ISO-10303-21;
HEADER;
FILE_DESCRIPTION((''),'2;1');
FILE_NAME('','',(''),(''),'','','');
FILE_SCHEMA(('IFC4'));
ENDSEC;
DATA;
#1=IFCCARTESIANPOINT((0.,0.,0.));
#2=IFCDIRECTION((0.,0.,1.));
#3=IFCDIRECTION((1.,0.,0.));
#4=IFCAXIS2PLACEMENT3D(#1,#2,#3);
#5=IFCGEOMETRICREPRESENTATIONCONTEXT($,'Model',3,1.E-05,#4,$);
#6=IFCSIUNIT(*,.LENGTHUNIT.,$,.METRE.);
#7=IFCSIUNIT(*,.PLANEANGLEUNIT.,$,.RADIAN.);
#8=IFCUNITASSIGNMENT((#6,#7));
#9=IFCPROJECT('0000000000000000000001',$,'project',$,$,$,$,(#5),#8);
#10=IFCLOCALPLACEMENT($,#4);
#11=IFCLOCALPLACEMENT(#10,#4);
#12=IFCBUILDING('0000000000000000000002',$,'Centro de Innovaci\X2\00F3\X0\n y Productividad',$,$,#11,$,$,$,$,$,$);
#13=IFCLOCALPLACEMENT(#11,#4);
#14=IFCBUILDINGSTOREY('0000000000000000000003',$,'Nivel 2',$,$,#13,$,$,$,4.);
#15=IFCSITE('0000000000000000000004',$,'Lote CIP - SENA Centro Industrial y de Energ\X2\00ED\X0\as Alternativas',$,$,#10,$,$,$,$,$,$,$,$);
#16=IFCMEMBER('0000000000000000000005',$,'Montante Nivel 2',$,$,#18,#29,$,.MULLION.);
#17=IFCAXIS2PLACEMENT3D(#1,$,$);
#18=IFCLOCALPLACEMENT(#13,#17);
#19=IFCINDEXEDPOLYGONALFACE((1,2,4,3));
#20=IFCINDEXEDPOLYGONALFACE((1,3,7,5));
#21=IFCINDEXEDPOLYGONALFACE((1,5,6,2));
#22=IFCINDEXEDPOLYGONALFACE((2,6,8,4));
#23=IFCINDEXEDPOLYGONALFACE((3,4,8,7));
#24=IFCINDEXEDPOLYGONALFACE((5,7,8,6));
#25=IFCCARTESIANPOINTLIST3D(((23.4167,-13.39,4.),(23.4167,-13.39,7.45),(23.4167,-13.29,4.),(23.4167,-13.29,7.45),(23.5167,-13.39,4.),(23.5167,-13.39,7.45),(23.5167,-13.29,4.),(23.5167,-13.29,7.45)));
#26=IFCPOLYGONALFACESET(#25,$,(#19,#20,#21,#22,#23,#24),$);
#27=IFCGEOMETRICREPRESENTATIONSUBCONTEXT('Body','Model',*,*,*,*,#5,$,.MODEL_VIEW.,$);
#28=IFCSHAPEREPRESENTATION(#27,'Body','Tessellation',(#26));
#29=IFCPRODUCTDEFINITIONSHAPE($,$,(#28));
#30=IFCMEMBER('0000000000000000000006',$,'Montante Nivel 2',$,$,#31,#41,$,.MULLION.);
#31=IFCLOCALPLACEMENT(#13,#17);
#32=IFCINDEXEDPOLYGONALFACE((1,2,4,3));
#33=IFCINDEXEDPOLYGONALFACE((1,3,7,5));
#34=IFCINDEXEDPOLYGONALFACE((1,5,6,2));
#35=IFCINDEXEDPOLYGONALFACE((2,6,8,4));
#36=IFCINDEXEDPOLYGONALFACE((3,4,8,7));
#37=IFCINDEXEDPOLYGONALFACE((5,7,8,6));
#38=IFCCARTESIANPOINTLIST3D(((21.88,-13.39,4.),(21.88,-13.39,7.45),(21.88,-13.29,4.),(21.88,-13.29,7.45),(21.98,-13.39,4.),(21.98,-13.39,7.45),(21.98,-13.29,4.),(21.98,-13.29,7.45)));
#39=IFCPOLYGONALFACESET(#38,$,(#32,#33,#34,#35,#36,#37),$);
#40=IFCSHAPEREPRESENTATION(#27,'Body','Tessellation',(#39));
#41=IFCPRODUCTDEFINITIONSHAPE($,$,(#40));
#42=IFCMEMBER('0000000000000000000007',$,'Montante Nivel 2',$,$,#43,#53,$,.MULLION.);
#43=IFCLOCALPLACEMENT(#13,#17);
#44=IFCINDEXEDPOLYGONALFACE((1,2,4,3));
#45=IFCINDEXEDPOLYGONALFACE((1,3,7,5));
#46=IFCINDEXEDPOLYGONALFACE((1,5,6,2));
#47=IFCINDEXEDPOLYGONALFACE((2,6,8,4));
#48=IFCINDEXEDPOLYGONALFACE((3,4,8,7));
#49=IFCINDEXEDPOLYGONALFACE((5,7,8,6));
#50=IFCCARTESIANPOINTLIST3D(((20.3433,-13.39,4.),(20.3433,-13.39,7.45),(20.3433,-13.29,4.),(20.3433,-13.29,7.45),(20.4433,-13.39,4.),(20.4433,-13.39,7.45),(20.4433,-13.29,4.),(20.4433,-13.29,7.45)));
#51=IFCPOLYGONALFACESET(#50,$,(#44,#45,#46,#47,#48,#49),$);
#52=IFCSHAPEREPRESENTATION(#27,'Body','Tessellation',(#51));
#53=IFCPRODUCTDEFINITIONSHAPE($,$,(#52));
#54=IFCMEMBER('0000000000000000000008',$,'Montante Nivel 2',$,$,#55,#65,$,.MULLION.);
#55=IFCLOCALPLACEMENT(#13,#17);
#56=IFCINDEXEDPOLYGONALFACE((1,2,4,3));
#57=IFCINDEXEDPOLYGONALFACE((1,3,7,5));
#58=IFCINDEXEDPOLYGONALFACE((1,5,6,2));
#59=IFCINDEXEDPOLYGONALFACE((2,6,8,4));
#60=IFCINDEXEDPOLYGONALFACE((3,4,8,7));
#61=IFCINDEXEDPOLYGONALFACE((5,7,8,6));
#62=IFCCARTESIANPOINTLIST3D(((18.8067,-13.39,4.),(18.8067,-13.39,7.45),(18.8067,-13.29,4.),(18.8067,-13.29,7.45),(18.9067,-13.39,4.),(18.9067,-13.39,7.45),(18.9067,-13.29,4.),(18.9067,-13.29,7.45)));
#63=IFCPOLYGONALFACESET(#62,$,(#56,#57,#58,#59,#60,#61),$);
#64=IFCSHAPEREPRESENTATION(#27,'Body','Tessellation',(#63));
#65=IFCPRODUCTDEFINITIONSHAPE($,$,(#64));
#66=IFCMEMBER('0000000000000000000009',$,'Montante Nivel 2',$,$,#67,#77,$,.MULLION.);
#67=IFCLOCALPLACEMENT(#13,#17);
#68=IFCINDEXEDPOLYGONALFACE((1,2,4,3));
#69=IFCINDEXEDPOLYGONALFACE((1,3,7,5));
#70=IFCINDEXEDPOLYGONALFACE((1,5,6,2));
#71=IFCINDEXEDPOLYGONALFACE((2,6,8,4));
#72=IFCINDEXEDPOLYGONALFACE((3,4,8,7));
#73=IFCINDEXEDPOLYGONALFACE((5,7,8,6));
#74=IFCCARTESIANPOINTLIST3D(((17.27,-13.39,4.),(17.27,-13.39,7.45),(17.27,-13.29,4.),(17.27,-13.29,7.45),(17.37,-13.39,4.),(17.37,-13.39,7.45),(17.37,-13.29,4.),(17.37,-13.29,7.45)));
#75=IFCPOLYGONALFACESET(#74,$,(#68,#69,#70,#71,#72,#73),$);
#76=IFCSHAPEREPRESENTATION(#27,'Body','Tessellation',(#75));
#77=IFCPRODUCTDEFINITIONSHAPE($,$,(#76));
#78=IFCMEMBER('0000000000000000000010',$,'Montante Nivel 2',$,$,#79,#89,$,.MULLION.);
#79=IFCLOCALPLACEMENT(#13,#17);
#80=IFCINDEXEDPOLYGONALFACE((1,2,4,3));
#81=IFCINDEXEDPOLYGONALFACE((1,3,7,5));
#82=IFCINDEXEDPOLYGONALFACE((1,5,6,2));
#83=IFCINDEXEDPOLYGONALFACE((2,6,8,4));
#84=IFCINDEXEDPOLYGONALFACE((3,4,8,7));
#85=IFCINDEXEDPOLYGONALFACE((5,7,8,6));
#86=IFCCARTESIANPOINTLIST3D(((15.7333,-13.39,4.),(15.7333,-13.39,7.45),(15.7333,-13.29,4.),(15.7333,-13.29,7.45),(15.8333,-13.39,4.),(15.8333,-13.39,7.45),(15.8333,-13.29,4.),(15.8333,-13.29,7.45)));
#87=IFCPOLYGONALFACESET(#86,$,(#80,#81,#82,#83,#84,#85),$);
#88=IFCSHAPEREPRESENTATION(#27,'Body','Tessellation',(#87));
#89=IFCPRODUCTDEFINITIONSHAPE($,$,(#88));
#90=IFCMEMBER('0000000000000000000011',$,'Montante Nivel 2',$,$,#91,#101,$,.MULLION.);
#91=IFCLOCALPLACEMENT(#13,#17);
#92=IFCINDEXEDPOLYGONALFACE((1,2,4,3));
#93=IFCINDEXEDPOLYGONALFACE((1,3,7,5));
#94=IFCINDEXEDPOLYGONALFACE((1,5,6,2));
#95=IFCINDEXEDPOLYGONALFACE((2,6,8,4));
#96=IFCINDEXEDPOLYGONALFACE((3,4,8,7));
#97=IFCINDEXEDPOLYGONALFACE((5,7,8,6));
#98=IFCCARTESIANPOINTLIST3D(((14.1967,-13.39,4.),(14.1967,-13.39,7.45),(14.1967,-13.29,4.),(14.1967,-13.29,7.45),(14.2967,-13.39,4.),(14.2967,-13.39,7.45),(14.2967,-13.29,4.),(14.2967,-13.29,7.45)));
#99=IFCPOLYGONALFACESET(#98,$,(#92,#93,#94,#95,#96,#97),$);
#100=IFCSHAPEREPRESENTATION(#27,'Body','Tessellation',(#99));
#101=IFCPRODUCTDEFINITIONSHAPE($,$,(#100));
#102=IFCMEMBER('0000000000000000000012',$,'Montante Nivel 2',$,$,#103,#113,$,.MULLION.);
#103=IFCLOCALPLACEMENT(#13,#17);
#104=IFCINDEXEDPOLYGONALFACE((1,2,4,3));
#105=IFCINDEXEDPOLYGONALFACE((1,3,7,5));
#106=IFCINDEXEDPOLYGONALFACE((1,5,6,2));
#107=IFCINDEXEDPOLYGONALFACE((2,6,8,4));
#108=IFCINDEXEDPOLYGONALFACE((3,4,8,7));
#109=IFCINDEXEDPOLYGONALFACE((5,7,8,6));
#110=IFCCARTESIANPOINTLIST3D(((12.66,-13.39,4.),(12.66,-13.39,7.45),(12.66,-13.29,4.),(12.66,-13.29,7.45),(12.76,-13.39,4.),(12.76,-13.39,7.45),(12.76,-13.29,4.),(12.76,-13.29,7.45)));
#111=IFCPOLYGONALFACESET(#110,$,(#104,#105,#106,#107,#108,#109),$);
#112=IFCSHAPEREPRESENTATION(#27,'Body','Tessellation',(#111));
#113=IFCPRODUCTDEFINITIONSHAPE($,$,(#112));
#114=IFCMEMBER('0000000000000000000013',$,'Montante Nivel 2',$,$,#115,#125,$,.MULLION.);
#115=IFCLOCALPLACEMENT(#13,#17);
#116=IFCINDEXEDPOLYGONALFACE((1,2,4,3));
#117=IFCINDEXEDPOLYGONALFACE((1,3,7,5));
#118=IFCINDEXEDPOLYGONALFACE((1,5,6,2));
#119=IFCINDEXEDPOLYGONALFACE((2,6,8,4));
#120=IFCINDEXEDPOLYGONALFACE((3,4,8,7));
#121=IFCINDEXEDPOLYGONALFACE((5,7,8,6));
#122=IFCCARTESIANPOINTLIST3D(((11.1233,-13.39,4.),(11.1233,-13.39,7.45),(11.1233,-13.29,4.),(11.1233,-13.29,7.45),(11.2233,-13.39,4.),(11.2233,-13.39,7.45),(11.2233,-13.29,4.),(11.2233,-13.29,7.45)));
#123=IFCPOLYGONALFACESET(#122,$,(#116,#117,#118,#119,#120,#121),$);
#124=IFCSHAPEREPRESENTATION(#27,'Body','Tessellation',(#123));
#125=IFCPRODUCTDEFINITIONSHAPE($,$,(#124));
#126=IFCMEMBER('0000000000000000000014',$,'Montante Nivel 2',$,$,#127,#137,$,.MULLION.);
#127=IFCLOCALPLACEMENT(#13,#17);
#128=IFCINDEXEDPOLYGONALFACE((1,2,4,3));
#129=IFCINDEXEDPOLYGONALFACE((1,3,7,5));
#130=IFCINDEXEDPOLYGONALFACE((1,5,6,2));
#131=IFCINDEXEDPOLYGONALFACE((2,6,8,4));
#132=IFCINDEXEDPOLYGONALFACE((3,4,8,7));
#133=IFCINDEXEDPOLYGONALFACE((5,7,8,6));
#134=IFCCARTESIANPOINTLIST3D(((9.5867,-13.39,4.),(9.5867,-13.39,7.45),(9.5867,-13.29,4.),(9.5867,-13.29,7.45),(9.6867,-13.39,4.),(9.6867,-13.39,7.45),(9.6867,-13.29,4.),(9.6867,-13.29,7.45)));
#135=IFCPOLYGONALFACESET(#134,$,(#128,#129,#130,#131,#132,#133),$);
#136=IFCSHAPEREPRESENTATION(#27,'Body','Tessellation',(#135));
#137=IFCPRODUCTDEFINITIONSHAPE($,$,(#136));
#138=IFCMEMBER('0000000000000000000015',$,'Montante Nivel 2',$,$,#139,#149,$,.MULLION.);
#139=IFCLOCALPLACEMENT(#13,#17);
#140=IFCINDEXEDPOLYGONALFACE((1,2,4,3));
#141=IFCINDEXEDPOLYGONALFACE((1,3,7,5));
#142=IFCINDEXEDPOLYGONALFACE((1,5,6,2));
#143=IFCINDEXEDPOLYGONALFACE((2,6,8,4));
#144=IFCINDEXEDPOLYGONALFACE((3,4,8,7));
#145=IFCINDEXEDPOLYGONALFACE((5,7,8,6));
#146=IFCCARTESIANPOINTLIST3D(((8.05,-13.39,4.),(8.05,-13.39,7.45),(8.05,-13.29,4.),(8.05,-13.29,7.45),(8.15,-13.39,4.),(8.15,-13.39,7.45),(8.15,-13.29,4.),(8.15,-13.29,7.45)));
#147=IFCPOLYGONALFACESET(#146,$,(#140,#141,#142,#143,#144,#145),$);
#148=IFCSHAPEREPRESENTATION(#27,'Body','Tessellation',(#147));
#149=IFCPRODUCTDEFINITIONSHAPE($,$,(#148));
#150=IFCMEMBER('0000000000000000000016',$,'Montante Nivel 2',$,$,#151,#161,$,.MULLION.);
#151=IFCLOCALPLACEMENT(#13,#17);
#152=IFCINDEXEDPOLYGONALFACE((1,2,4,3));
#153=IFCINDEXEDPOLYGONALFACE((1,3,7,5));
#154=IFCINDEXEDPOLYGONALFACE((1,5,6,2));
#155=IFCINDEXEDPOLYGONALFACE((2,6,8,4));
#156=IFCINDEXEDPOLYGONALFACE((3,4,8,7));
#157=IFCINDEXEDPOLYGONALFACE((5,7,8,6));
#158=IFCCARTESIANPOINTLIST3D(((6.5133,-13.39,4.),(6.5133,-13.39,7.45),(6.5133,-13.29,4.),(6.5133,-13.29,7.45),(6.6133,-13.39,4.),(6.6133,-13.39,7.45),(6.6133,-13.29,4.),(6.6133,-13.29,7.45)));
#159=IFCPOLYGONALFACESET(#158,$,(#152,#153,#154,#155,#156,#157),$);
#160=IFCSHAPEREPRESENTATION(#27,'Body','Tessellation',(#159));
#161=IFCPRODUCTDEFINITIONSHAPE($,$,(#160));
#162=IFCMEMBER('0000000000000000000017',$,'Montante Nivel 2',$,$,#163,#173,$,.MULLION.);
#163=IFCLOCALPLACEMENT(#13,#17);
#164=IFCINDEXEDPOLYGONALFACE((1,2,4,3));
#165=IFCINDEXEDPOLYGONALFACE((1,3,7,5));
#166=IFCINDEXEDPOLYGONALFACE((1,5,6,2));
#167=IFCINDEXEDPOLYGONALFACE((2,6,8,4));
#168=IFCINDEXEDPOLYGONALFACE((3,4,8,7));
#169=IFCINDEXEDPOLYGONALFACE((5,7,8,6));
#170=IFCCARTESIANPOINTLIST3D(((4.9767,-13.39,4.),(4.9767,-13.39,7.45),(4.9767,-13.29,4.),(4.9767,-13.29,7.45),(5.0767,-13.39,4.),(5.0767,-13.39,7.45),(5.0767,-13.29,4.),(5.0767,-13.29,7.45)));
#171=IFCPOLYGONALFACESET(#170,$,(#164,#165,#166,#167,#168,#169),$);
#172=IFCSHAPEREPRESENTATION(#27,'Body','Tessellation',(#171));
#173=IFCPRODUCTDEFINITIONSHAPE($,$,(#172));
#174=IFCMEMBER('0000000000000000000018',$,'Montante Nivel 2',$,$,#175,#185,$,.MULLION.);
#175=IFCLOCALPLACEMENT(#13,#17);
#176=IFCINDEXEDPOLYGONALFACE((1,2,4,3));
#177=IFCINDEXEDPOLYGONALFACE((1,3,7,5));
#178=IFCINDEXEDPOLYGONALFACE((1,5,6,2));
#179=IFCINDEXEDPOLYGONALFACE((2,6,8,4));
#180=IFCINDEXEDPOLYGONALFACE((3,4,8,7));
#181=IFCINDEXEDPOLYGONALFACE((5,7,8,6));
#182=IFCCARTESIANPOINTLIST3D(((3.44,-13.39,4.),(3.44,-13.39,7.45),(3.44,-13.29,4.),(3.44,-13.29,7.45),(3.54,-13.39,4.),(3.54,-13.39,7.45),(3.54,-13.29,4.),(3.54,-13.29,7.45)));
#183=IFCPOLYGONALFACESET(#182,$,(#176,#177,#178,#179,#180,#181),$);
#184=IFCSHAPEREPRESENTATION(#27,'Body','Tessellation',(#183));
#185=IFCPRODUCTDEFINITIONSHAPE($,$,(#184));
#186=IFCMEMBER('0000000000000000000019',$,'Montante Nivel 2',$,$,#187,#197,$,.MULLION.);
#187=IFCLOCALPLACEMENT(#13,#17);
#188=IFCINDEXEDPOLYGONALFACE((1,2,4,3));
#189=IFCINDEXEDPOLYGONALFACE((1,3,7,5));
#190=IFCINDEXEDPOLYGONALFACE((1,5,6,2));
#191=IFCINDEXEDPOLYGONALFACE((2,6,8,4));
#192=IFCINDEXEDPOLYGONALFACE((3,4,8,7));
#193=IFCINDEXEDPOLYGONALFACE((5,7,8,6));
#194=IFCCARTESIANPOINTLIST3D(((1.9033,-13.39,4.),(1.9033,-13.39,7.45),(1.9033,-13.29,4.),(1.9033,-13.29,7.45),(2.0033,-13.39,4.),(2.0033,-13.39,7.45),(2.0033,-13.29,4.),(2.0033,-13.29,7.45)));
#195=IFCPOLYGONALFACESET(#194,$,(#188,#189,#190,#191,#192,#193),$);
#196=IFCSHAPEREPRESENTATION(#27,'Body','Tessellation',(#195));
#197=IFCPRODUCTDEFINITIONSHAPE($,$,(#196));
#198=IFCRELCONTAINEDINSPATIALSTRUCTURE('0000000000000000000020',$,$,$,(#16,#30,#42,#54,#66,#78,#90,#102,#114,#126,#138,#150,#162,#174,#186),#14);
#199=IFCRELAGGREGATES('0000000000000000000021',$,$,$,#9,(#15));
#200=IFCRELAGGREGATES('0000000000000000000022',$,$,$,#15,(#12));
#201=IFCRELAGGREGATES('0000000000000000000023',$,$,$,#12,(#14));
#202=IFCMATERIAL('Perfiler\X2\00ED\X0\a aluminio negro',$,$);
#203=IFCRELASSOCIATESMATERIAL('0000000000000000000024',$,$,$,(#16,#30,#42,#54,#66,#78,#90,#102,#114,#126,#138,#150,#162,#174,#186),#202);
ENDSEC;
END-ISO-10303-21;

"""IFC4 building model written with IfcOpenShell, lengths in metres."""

from ifc_helpers import new_model, si_unit, frame, origin_with_axes, place, context, subcontext, project, spatial, polyline, outline, extrude, material, element, save


model = new_model("IFC4")

# Units and contexts
model_context = context("Model", 3, precision=1e-05, world=origin_with_axes())
body_context = subcontext(model_context, "Body", "Model", "MODEL_VIEW")
ifc_project = project(units=[si_unit("LENGTHUNIT", "METRE"), si_unit("PLANEANGLEUNIT", "RADIAN")], contexts=[model_context])

# Site, building, storey
site_placement = place(None, origin_with_axes())
site = spatial("IfcSite", under=ifc_project, at=site_placement, Name="Lote CIP - SENA Centro Industrial y de Energías Alternativas")
building_placement = place(site_placement, origin_with_axes())
building = spatial("IfcBuilding", under=site, at=building_placement, Name="Centro de Innovación y Productividad")
storey_placement = place(building_placement, origin_with_axes())
storey = spatial("IfcBuildingStorey", under=building, at=storey_placement, Name="Nivel 2", Elevation=4.0)

# Members
ifc_material_1 = material(Name="Perfilería aluminio negro")
member_1_placement = place(storey_placement, origin_with_axes())
element("IfcMember", 1, at=member_1_placement, inside=storey, material=ifc_material_1, Name="Montante Nivel 2", PredefinedType="MULLION", context=body_context, shape_type="SweptSolid", body=[
    extrude(outline(polyline([(23.5167, -13.29), (23.5167, -13.39), (23.4167, -13.39), (23.4167, -13.29), (23.5167, -13.29)])), frame((0.0, 0.0, 4.0)), (0.0, 0.0, 1.0), 3.45),
])
member_2_placement = place(storey_placement, origin_with_axes())
element("IfcMember", 2, at=member_2_placement, inside=storey, material=ifc_material_1, Name="Montante Nivel 2", PredefinedType="MULLION", context=body_context, shape_type="SweptSolid", body=[
    extrude(outline(polyline([(21.98, -13.29), (21.98, -13.39), (21.88, -13.39), (21.88, -13.29), (21.98, -13.29)])), frame((0.0, 0.0, 4.0)), (0.0, 0.0, 1.0), 3.45),
])
member_3_placement = place(storey_placement, origin_with_axes())
element("IfcMember", 3, at=member_3_placement, inside=storey, material=ifc_material_1, Name="Montante Nivel 2", PredefinedType="MULLION", context=body_context, shape_type="SweptSolid", body=[
    extrude(outline(polyline([(20.4433, -13.29), (20.4433, -13.39), (20.3433, -13.39), (20.3433, -13.29), (20.4433, -13.29)])), frame((0.0, 0.0, 4.0)), (0.0, 0.0, 1.0), 3.45),
])
member_4_placement = place(storey_placement, origin_with_axes())
element("IfcMember", 4, at=member_4_placement, inside=storey, material=ifc_material_1, Name="Montante Nivel 2", PredefinedType="MULLION", context=body_context, shape_type="SweptSolid", body=[
    extrude(outline(polyline([(18.9067, -13.29), (18.9067, -13.39), (18.8067, -13.39), (18.8067, -13.29), (18.9067, -13.29)])), frame((0.0, 0.0, 4.0)), (0.0, 0.0, 1.0), 3.45),
])
member_5_placement = place(storey_placement, origin_with_axes())
element("IfcMember", 5, at=member_5_placement, inside=storey, material=ifc_material_1, Name="Montante Nivel 2", PredefinedType="MULLION", context=body_context, shape_type="SweptSolid", body=[
    extrude(outline(polyline([(17.37, -13.29), (17.37, -13.39), (17.27, -13.39), (17.27, -13.29), (17.37, -13.29)])), frame((0.0, 0.0, 4.0)), (0.0, 0.0, 1.0), 3.45),
])
member_6_placement = place(storey_placement, origin_with_axes())
element("IfcMember", 6, at=member_6_placement, inside=storey, material=ifc_material_1, Name="Montante Nivel 2", PredefinedType="MULLION", context=body_context, shape_type="SweptSolid", body=[
    extrude(outline(polyline([(15.8333, -13.29), (15.8333, -13.39), (15.7333, -13.39), (15.7333, -13.29), (15.8333, -13.29)])), frame((0.0, 0.0, 4.0)), (0.0, 0.0, 1.0), 3.45),
])
member_7_placement = place(storey_placement, origin_with_axes())
element("IfcMember", 7, at=member_7_placement, inside=storey, material=ifc_material_1, Name="Montante Nivel 2", PredefinedType="MULLION", context=body_context, shape_type="SweptSolid", body=[
    extrude(outline(polyline([(14.2967, -13.29), (14.2967, -13.39), (14.1967, -13.39), (14.1967, -13.29), (14.2967, -13.29)])), frame((0.0, 0.0, 4.0)), (0.0, 0.0, 1.0), 3.45),
])
member_8_placement = place(storey_placement, origin_with_axes())
element("IfcMember", 8, at=member_8_placement, inside=storey, material=ifc_material_1, Name="Montante Nivel 2", PredefinedType="MULLION", context=body_context, shape_type="SweptSolid", body=[
    extrude(outline(polyline([(12.76, -13.29), (12.76, -13.39), (12.66, -13.39), (12.66, -13.29), (12.76, -13.29)])), frame((0.0, 0.0, 4.0)), (0.0, 0.0, 1.0), 3.45),
])
member_9_placement = place(storey_placement, origin_with_axes())
element("IfcMember", 9, at=member_9_placement, inside=storey, material=ifc_material_1, Name="Montante Nivel 2", PredefinedType="MULLION", context=body_context, shape_type="SweptSolid", body=[
    extrude(outline(polyline([(11.2233, -13.29), (11.2233, -13.39), (11.1233, -13.39), (11.1233, -13.29), (11.2233, -13.29)])), frame((0.0, 0.0, 4.0)), (0.0, 0.0, 1.0), 3.45),
])
member_10_placement = place(storey_placement, origin_with_axes())
element("IfcMember", 10, at=member_10_placement, inside=storey, material=ifc_material_1, Name="Montante Nivel 2", PredefinedType="MULLION", context=body_context, shape_type="SweptSolid", body=[
    extrude(outline(polyline([(9.6867, -13.29), (9.6867, -13.39), (9.5867, -13.39), (9.5867, -13.29), (9.6867, -13.29)])), frame((0.0, 0.0, 4.0)), (0.0, 0.0, 1.0), 3.45),
])
member_11_placement = place(storey_placement, origin_with_axes())
element("IfcMember", 11, at=member_11_placement, inside=storey, material=ifc_material_1, Name="Montante Nivel 2", PredefinedType="MULLION", context=body_context, shape_type="SweptSolid", body=[
    extrude(outline(polyline([(8.15, -13.29), (8.15, -13.39), (8.05, -13.39), (8.05, -13.29), (8.15, -13.29)])), frame((0.0, 0.0, 4.0)), (0.0, 0.0, 1.0), 3.45),
])
member_12_placement = place(storey_placement, origin_with_axes())
element("IfcMember", 12, at=member_12_placement, inside=storey, material=ifc_material_1, Name="Montante Nivel 2", PredefinedType="MULLION", context=body_context, shape_type="SweptSolid", body=[
    extrude(outline(polyline([(6.6133, -13.29), (6.6133, -13.39), (6.5133, -13.39), (6.5133, -13.29), (6.6133, -13.29)])), frame((0.0, 0.0, 4.0)), (0.0, 0.0, 1.0), 3.45),
])
member_13_placement = place(storey_placement, origin_with_axes())
element("IfcMember", 13, at=member_13_placement, inside=storey, material=ifc_material_1, Name="Montante Nivel 2", PredefinedType="MULLION", context=body_context, shape_type="SweptSolid", body=[
    extrude(outline(polyline([(5.0767, -13.29), (5.0767, -13.39), (4.9767, -13.39), (4.9767, -13.29), (5.0767, -13.29)])), frame((0.0, 0.0, 4.0)), (0.0, 0.0, 1.0), 3.45),
])
member_14_placement = place(storey_placement, origin_with_axes())
element("IfcMember", 14, at=member_14_placement, inside=storey, material=ifc_material_1, Name="Montante Nivel 2", PredefinedType="MULLION", context=body_context, shape_type="SweptSolid", body=[
    extrude(outline(polyline([(3.54, -13.29), (3.54, -13.39), (3.44, -13.39), (3.44, -13.29), (3.54, -13.29)])), frame((0.0, 0.0, 4.0)), (0.0, 0.0, 1.0), 3.45),
])
member_15_placement = place(storey_placement, origin_with_axes())
element("IfcMember", 15, at=member_15_placement, inside=storey, material=ifc_material_1, Name="Montante Nivel 2", PredefinedType="MULLION", context=body_context, shape_type="SweptSolid", body=[
    extrude(outline(polyline([(2.0033, -13.29), (2.0033, -13.39), (1.9033, -13.39), (1.9033, -13.29), (2.0033, -13.29)])), frame((0.0, 0.0, 4.0)), (0.0, 0.0, 1.0), 3.45),
])

save(model, "model.ifc")
